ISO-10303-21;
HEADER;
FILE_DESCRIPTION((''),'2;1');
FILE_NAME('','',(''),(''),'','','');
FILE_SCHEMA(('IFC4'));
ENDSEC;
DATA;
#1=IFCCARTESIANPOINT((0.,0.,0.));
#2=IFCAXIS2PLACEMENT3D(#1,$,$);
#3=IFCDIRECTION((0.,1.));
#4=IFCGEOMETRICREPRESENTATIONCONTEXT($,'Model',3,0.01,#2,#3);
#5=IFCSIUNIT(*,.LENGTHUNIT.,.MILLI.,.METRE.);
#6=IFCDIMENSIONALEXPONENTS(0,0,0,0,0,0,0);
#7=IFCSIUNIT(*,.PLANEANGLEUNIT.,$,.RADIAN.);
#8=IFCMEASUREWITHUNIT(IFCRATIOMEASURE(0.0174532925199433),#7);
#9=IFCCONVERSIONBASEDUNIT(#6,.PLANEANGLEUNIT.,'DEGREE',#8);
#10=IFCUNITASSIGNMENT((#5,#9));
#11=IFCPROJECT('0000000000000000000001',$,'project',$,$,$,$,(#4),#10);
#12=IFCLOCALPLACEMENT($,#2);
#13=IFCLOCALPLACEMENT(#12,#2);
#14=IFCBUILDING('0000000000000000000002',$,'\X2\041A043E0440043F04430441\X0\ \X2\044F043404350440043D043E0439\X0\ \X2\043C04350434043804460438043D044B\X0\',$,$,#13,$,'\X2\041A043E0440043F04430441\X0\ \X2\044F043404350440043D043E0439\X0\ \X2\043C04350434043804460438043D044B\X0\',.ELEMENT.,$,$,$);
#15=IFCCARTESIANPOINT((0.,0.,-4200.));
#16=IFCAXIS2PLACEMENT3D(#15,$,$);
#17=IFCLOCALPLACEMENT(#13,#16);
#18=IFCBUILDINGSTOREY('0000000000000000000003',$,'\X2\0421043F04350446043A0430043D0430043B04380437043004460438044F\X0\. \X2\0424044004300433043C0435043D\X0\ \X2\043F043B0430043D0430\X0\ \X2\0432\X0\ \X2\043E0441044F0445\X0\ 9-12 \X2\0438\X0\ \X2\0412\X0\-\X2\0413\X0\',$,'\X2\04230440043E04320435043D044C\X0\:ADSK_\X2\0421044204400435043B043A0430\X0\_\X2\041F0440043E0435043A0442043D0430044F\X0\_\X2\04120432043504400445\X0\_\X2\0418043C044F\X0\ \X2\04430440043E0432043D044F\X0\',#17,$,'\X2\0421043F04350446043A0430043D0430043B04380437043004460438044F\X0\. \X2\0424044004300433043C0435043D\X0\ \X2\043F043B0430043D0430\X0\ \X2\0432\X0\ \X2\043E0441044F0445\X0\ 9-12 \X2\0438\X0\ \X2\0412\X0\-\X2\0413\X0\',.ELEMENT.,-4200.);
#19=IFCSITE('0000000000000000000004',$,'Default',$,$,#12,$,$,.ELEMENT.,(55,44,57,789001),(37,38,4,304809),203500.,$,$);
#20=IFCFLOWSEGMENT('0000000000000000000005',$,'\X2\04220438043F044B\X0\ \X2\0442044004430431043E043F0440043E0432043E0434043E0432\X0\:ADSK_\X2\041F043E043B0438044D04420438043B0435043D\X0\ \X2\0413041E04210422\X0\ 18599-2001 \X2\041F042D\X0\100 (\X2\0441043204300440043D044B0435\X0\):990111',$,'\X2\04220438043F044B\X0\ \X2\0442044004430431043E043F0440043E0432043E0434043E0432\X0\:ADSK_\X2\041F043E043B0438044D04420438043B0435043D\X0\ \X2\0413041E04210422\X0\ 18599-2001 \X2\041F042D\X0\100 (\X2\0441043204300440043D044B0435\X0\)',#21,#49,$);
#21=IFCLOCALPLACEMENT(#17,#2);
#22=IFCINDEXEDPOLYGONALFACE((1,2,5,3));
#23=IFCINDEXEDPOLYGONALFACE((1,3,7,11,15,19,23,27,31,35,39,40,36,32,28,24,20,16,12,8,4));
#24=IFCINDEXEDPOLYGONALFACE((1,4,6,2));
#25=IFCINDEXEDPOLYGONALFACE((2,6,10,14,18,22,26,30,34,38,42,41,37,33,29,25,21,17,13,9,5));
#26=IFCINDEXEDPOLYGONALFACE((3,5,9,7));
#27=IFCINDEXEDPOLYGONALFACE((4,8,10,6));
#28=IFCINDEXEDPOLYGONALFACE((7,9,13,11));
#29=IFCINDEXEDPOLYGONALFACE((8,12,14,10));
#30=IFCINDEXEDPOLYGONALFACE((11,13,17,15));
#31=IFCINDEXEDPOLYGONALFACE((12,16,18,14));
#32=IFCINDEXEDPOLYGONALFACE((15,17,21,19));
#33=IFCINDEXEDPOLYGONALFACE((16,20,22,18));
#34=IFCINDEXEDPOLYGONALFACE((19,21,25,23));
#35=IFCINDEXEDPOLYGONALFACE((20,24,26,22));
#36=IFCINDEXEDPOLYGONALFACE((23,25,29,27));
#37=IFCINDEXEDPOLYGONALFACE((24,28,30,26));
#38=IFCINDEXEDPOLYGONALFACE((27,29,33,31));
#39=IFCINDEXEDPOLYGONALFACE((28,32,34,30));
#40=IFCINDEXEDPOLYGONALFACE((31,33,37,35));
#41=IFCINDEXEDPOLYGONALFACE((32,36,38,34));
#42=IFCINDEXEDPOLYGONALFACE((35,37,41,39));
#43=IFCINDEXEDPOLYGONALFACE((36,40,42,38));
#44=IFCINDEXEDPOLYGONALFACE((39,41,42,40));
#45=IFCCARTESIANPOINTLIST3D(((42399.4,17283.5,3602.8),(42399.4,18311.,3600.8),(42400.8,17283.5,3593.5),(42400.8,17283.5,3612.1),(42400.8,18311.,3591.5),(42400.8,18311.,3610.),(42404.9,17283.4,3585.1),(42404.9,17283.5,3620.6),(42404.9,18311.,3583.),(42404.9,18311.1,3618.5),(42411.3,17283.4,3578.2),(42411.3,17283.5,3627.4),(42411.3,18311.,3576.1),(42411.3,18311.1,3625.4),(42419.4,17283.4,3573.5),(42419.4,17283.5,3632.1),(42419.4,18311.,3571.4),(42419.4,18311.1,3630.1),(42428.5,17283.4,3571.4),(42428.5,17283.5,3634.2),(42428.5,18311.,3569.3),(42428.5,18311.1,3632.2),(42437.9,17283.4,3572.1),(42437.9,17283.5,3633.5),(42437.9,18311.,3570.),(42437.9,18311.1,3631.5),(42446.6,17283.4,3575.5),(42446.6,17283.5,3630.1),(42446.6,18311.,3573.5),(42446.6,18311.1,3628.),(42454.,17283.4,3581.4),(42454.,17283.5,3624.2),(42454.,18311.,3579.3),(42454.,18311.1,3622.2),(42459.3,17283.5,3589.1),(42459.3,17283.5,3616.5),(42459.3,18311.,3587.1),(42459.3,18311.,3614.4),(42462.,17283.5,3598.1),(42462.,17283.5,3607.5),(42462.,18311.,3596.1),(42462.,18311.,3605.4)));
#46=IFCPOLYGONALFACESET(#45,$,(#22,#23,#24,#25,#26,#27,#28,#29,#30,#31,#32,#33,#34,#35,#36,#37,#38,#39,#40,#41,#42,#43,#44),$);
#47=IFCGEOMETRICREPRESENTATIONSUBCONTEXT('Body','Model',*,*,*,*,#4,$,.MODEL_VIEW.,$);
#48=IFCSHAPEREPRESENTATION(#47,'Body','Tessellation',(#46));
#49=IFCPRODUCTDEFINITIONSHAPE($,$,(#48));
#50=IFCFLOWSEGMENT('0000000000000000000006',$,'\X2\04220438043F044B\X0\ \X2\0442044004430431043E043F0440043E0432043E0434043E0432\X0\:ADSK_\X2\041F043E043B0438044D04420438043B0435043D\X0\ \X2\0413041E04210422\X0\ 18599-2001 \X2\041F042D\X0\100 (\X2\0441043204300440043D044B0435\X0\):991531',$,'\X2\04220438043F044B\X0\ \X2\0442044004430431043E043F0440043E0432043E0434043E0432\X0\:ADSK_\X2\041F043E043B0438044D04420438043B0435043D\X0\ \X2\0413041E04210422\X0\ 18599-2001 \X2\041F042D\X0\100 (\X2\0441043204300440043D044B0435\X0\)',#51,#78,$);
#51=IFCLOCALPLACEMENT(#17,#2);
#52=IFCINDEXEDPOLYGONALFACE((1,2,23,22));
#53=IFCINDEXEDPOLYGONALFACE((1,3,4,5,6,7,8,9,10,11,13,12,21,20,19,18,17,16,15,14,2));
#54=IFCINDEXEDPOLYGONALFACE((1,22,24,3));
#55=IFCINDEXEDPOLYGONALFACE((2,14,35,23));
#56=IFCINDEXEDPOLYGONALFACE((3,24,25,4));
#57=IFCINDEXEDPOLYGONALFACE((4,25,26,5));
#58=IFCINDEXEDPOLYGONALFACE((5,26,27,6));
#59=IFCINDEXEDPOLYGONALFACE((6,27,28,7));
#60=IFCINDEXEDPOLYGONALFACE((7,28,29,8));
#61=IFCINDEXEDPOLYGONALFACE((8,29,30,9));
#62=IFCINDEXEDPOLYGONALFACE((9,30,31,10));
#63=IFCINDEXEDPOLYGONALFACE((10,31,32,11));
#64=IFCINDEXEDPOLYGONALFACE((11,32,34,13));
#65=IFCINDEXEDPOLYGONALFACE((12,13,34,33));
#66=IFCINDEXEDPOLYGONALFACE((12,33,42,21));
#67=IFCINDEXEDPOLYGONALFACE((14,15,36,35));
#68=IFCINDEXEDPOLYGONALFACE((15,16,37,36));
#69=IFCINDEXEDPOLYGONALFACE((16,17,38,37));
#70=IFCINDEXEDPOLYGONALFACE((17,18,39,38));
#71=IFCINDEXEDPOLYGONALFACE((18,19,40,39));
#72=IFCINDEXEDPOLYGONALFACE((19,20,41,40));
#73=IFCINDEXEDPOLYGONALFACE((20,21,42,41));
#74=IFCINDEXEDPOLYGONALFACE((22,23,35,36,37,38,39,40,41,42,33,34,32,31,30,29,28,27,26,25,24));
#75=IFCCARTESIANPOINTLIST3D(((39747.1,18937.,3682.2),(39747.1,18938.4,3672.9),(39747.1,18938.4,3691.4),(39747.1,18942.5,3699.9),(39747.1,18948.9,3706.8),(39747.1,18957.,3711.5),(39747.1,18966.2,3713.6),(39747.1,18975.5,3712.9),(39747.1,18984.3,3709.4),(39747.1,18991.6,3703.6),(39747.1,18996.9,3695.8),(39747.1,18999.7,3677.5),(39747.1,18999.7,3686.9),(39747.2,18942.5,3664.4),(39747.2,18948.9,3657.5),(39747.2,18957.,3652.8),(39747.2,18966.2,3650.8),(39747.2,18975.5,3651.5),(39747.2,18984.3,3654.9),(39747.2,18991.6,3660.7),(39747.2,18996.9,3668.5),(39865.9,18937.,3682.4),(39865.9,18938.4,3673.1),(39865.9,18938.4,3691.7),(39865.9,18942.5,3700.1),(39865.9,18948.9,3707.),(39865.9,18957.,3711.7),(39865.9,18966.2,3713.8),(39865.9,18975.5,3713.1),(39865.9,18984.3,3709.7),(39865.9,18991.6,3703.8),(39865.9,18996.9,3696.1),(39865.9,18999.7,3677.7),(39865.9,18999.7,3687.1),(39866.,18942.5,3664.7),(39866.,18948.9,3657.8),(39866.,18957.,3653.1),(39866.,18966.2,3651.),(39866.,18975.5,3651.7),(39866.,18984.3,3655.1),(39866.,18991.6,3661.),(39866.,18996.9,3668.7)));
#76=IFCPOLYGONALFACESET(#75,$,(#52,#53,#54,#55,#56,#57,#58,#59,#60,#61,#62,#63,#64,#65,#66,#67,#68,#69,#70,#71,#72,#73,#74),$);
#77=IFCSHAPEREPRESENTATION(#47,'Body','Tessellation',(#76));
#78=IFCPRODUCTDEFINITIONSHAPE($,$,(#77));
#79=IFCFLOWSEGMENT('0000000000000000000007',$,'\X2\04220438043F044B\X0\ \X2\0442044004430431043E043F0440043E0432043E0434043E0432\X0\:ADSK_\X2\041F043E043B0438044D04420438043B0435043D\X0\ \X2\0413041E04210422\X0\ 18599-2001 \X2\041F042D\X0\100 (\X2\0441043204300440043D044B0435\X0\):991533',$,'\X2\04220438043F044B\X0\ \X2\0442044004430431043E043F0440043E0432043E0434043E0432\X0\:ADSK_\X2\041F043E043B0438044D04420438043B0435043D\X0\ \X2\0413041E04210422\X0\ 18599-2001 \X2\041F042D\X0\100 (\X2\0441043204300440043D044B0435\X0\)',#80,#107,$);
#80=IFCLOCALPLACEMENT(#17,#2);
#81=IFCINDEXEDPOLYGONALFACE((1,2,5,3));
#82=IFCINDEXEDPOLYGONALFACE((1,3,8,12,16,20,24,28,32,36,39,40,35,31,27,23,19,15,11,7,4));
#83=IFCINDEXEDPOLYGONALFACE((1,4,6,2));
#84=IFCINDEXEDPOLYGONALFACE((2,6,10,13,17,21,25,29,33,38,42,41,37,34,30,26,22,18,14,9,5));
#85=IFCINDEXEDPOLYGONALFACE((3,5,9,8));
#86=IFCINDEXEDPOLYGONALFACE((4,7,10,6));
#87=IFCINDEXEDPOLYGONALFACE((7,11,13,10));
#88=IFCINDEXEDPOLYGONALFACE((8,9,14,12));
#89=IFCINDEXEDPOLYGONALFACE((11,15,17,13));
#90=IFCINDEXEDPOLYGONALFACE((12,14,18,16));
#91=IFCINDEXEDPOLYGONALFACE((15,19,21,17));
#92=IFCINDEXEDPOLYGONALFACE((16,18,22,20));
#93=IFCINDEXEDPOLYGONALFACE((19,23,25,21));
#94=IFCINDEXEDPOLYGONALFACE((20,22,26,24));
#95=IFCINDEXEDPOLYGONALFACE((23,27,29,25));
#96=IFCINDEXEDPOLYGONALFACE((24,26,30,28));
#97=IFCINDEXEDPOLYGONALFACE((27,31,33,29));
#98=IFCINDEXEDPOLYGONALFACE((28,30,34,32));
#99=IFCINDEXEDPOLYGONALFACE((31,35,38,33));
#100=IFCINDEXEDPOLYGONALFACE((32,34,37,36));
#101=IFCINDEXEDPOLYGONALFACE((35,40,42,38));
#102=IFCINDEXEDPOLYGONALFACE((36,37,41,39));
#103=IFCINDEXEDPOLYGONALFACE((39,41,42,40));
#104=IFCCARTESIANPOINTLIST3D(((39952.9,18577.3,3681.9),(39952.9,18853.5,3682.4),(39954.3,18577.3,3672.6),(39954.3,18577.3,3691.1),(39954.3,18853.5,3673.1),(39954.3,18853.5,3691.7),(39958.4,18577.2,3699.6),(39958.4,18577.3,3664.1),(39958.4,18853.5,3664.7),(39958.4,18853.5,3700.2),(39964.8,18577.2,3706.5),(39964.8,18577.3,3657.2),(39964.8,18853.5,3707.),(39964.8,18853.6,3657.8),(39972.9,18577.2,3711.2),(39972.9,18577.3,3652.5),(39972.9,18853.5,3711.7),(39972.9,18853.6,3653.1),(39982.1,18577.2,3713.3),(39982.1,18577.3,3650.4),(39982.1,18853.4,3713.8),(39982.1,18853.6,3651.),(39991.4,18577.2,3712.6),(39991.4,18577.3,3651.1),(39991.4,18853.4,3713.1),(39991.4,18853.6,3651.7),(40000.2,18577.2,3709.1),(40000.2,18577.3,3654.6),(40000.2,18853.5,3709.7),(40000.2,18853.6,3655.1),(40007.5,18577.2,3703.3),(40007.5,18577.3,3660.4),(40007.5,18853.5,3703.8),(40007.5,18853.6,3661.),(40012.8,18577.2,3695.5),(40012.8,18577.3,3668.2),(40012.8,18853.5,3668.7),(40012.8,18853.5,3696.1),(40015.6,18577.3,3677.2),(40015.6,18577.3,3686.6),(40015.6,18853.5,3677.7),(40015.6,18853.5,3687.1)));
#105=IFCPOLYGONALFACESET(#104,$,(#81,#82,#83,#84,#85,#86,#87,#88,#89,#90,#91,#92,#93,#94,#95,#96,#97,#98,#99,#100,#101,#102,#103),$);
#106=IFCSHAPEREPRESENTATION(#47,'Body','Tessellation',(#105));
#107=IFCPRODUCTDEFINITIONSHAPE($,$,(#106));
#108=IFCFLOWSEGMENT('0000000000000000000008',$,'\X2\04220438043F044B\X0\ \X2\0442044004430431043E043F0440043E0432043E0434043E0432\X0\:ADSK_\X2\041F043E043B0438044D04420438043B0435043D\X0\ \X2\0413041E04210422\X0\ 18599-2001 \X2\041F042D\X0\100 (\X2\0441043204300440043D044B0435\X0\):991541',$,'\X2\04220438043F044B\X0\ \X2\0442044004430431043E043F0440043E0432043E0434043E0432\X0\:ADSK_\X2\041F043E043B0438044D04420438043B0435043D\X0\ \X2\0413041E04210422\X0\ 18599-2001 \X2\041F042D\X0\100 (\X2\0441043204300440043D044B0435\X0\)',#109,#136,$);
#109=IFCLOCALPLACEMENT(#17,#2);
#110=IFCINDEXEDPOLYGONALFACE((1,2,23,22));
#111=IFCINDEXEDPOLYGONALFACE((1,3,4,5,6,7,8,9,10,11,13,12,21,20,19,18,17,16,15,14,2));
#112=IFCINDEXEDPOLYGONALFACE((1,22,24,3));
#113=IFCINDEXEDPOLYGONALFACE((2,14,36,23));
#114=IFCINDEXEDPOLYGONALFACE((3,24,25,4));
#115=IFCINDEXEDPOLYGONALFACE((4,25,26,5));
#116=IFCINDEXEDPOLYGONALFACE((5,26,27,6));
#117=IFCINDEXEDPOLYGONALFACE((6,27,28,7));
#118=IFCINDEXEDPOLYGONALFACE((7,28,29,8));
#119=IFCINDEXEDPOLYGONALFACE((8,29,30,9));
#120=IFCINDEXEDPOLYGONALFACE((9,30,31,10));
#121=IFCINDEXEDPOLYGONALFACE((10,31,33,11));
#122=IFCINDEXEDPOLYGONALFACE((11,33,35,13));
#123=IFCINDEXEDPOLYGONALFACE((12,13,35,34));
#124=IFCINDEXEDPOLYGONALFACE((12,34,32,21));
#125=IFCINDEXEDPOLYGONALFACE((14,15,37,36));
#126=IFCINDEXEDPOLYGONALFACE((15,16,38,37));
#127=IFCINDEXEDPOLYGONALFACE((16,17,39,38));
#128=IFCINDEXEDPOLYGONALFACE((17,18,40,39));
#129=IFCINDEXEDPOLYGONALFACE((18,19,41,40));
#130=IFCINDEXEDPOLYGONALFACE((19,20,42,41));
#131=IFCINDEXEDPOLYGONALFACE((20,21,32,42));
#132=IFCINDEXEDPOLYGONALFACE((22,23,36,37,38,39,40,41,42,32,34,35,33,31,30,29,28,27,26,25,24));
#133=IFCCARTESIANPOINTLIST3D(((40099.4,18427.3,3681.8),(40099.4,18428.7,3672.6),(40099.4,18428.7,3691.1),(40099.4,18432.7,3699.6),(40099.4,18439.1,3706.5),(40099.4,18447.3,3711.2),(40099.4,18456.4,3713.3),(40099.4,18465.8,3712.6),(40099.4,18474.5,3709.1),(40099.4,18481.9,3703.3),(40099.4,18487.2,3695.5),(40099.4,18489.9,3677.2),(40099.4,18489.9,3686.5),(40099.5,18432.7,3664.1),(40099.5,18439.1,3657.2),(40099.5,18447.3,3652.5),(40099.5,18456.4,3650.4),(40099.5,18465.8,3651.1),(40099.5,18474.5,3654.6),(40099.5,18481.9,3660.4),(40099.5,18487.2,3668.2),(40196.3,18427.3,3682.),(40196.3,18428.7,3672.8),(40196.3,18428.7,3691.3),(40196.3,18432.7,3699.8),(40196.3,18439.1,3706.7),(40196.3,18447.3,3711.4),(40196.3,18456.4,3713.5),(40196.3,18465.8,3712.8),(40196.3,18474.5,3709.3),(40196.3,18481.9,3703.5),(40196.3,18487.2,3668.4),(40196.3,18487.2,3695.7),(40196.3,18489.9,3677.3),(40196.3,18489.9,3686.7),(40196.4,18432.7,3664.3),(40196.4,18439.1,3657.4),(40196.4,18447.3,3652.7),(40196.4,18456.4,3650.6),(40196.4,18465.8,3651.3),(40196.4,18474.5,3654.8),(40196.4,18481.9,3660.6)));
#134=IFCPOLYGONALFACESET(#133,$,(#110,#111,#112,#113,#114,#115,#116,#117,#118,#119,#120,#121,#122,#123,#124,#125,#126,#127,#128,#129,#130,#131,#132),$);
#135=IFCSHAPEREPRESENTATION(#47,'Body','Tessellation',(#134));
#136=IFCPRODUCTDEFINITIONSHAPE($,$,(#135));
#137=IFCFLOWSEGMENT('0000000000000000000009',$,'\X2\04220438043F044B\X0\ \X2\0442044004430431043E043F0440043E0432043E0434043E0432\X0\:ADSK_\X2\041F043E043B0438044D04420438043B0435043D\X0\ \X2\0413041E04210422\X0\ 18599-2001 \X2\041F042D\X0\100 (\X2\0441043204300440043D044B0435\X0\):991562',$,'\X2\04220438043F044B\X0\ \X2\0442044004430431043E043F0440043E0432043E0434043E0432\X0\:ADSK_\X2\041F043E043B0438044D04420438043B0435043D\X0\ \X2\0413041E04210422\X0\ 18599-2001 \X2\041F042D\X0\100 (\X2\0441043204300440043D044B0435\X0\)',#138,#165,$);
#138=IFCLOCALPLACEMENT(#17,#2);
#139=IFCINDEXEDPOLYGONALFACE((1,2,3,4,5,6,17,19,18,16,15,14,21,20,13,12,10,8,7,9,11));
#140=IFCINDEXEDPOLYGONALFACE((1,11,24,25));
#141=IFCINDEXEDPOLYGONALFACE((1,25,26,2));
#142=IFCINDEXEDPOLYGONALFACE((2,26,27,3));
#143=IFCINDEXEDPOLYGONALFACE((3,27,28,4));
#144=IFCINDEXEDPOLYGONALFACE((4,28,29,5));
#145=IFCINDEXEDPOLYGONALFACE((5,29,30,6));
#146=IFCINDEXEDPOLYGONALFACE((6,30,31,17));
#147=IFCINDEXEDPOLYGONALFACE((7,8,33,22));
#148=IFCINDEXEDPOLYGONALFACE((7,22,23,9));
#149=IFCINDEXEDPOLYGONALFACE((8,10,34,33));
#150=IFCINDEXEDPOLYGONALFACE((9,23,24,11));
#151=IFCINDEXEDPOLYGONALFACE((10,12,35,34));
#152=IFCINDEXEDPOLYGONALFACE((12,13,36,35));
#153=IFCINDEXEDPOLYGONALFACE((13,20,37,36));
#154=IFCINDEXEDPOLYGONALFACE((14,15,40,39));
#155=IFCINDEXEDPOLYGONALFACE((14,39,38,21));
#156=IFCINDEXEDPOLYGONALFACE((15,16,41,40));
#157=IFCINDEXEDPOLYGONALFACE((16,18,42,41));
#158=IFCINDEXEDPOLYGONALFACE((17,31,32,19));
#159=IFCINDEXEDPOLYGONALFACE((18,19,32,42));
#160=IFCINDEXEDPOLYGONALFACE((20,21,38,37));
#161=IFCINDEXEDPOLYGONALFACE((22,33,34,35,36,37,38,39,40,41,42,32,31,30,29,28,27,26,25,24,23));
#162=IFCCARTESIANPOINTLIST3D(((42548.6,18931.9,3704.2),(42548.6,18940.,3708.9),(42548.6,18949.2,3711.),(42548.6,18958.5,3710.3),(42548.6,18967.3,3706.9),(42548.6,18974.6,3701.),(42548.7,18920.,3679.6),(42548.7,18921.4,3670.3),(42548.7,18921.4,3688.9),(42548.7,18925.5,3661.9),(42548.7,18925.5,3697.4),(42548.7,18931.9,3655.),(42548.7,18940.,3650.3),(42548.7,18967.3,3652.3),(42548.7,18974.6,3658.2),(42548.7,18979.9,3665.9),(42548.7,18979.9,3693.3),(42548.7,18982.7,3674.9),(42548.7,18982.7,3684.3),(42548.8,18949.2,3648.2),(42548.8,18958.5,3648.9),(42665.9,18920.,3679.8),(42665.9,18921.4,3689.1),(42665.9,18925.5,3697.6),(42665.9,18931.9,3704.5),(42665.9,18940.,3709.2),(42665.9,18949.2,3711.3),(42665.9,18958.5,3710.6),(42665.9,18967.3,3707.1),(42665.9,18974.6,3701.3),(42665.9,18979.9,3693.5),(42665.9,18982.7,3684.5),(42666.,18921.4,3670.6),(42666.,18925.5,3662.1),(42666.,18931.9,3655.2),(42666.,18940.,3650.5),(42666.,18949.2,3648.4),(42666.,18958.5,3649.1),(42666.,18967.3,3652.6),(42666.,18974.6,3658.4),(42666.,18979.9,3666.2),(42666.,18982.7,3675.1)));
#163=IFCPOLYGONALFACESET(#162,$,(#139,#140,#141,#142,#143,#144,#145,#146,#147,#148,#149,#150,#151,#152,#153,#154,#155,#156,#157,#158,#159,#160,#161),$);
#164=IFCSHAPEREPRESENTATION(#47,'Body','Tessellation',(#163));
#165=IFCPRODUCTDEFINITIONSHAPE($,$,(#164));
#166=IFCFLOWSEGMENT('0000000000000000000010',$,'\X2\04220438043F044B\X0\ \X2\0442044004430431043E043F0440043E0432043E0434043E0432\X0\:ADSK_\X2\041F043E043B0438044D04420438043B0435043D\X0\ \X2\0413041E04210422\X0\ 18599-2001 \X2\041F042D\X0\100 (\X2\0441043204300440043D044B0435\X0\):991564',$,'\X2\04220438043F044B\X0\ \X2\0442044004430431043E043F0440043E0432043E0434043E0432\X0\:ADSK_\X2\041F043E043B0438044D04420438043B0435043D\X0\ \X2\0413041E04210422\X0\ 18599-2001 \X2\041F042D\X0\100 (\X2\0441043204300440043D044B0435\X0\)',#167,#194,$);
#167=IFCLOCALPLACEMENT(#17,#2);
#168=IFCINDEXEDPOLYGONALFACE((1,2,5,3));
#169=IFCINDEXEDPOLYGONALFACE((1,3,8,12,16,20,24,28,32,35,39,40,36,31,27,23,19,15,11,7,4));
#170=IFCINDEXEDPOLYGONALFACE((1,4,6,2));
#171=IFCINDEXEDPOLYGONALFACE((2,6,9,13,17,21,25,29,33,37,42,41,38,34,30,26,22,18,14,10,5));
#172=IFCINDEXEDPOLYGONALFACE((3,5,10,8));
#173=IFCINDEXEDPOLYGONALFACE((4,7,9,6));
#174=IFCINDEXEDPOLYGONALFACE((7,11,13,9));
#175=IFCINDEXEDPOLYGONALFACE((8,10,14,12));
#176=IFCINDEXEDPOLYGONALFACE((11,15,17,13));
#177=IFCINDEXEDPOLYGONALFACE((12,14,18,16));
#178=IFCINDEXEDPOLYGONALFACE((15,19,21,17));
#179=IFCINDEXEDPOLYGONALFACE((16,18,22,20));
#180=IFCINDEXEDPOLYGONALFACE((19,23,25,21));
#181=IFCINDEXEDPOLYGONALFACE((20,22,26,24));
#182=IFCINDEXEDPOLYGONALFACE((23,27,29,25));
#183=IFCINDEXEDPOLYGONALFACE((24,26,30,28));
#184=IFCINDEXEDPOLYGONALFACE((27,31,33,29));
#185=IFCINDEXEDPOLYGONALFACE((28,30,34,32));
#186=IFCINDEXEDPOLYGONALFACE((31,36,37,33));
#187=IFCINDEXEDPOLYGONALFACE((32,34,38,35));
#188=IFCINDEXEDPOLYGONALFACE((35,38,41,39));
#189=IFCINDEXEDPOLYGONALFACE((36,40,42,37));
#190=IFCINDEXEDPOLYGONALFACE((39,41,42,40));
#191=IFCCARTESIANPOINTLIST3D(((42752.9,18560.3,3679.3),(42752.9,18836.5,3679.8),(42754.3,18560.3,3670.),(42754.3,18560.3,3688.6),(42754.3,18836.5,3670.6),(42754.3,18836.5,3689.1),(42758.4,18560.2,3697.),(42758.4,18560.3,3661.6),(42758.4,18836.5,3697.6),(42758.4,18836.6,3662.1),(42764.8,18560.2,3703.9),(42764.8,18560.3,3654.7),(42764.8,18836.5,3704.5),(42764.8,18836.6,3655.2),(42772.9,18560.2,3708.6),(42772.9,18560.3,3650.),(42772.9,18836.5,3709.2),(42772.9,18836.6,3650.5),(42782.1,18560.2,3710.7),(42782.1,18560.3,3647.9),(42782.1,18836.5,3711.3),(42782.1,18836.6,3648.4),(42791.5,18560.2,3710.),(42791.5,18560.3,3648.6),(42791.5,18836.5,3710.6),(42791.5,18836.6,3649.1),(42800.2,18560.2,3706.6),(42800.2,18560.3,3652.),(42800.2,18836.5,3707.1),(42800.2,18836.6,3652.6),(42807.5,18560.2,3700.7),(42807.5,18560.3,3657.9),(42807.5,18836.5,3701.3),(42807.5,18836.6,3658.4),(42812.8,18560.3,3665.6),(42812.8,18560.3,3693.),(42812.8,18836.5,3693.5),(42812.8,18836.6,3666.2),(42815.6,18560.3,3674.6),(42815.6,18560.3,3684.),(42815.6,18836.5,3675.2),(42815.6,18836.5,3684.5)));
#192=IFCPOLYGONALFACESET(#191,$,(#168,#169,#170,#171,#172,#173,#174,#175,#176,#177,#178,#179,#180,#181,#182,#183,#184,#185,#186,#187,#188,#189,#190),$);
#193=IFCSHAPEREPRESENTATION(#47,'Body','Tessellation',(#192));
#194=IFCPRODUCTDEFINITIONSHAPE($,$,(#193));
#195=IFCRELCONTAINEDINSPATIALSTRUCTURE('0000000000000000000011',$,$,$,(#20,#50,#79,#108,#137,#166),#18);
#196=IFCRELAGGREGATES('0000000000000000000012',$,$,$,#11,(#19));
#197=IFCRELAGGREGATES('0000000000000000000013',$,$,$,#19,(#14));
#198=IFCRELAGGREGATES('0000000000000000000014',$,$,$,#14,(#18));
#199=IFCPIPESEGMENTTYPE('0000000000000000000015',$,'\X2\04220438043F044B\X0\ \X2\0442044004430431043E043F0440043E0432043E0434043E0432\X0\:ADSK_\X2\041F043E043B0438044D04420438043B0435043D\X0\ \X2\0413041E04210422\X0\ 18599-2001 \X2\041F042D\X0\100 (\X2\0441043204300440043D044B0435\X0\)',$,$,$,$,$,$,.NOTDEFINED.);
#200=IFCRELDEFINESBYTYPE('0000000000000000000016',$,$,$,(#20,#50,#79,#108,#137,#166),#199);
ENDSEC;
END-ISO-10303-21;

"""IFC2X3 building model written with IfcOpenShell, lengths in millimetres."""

from ifc_helpers import new_model, entity, si_unit, converted_unit, direction, frame, frame_2d, origin, origin_2d_with_axis, place, context, subcontext, project, spatial, circle, extrude, type_object, element, save


model = new_model("IFC2X3")

# Units and contexts
model_context = context("Model", 3, precision=0.01, world=origin(), true_north=direction((0.0, 1.0)))
body_context = subcontext(model_context, "Body", "Model", "MODEL_VIEW")
ifc_project = project(units=[si_unit("LENGTHUNIT", "METRE", prefix="MILLI"), converted_unit("PLANEANGLEUNIT", "DEGREE", entity("IfcRatioMeasure", 0.0174532925199433), si_unit("PLANEANGLEUNIT", "RADIAN"), dimensions=[0, 0, 0, 0, 0, 0, 0])], contexts=[model_context])

# Site, building, storey
site_placement = place(None, frame((0.0, 0.0, 0.0)))
site = spatial("IfcSite", under=ifc_project, at=site_placement, Name="Default", CompositionType="ELEMENT", RefLatitude=(55, 44, 57, 789001), RefLongitude=(37, 38, 4, 304809), RefElevation=203500.0)
building_placement = place(site_placement, origin())
building = spatial("IfcBuilding", under=site, at=building_placement, Name="Корпус ядерной медицины", LongName="Корпус ядерной медицины", CompositionType="ELEMENT")
storey_placement = place(building_placement, frame((0.0, 0.0, -4200.0)))
storey = spatial("IfcBuildingStorey", under=building, at=storey_placement, Name="Спецканализация. Фрагмен плана в осях 9-12 и В-Г", ObjectType="Уровень:ADSK_Стрелка_Проектная_Вверх_Имя уровня", LongName="Спецканализация. Фрагмен плана в осях 9-12 и В-Г", CompositionType="ELEMENT", Elevation=-4200.0)

# Flow segments
pipe_segment_type = type_object("IfcPipeSegmentType", Name="Типы трубопроводов:ADSK_Полиэтилен ГОСТ 18599-2001 ПЭ100 (сварные)", PredefinedType="NOTDEFINED")
flow_segment_1_placement = place(storey_placement, frame((42397.8, 17283.4, 3567.7)))
element("IfcFlowSegment", 1, at=flow_segment_1_placement, inside=storey, type_object=pipe_segment_type, Name="Типы трубопроводов:ADSK_Полиэтилен ГОСТ 18599-2001 ПЭ100 (сварные):990111", ObjectType="Типы трубопроводов:ADSK_Полиэтилен ГОСТ 18599-2001 ПЭ100 (сварные)", context=body_context, shape_type="SweptSolid", body=[
    extrude(circle(Radius=31.5, at=frame_2d((0.0, 0.0), x_axis=(1.0, 0.0))), frame((33.1, 1027.6, 33.1), z_axis=(0.0, -0.999998, 0.002), x_axis=(-1.0, 0.0, 0.0)), (0.0, 0.0, 1.0), 1027.5),
])
flow_segment_2_placement = place(storey_placement, frame((39747.1, 18935.4, 3649.1)))
element("IfcFlowSegment", 2, at=flow_segment_2_placement, inside=storey, type_object=pipe_segment_type, Name="Типы трубопроводов:ADSK_Полиэтилен ГОСТ 18599-2001 ПЭ100 (сварные):991531", ObjectType="Типы трубопроводов:ADSK_Полиэтилен ГОСТ 18599-2001 ПЭ100 (сварные)", context=body_context, shape_type="SweptSolid", body=[
    extrude(circle(Radius=31.5, at=origin_2d_with_axis()), frame((0.1, 33.1, 33.1), z_axis=(0.999998, -0.000005, 0.002), x_axis=(-0.000005, -1.0, 0.0)), (0.0, 0.0, 1.0), 118.8),
])
flow_segment_3_placement = place(storey_placement, frame((39951.3, 18577.2, 3648.8)))
element("IfcFlowSegment", 3, at=flow_segment_3_placement, inside=storey, type_object=pipe_segment_type, Name="Типы трубопроводов:ADSK_Полиэтилен ГОСТ 18599-2001 ПЭ100 (сварные):991533", ObjectType="Типы трубопроводов:ADSK_Полиэтилен ГОСТ 18599-2001 ПЭ100 (сварные)", context=body_context, shape_type="SweptSolid", body=[
    extrude(circle(Radius=31.5, at=frame_2d((0.0, 0.0), x_axis=(1.0, 0.0))), frame((33.1, 0.1, 33.1), z_axis=(-0.000004, 0.999998, 0.002), x_axis=(-1.0, -0.000004, 0.0)), (0.0, 0.0, 1.0), 276.2),
])
flow_segment_4_placement = place(storey_placement, frame((40099.4, 18425.7, 3648.8)))
element("IfcFlowSegment", 4, at=flow_segment_4_placement, inside=storey, type_object=pipe_segment_type, Name="Типы трубопроводов:ADSK_Полиэтилен ГОСТ 18599-2001 ПЭ100 (сварные):991541", ObjectType="Типы трубопроводов:ADSK_Полиэтилен ГОСТ 18599-2001 ПЭ100 (сварные)", context=body_context, shape_type="SweptSolid", body=[
    extrude(circle(Radius=31.5, at=origin_2d_with_axis()), frame((0.1, 33.1, 33.1), z_axis=(0.999998, 0.0, 0.001997), x_axis=(0.0, -1.0, 0.0)), (0.0, 0.0, 1.0), 96.9),
])
flow_segment_5_placement = place(storey_placement, frame((42548.6, 18918.4, 3646.5)))
element("IfcFlowSegment", 5, at=flow_segment_5_placement, inside=storey, type_object=pipe_segment_type, Name="Типы трубопроводов:ADSK_Полиэтилен ГОСТ 18599-2001 ПЭ100 (сварные):991562", ObjectType="Типы трубопроводов:ADSK_Полиэтилен ГОСТ 18599-2001 ПЭ100 (сварные)", context=body_context, shape_type="SweptSolid", body=[
    extrude(circle(Radius=31.5, at=origin_2d_with_axis()), frame((0.1, 33.1, 33.1), z_axis=(0.999998, -0.000005, 0.002), x_axis=(-0.000005, -1.0, 0.0)), (0.0, 0.0, 1.0), 117.3),
])
flow_segment_6_placement = place(storey_placement, frame((42751.3, 18560.2, 3646.2)))
element("IfcFlowSegment", 6, at=flow_segment_6_placement, inside=storey, type_object=pipe_segment_type, Name="Типы трубопроводов:ADSK_Полиэтилен ГОСТ 18599-2001 ПЭ100 (сварные):991564", ObjectType="Типы трубопроводов:ADSK_Полиэтилен ГОСТ 18599-2001 ПЭ100 (сварные)", context=body_context, shape_type="SweptSolid", body=[
    extrude(circle(Radius=31.5, at=frame_2d((0.0, 0.0), x_axis=(1.0, 0.0))), frame((33.1, 0.1, 33.1), z_axis=(-0.000004, 0.999998, 0.002), x_axis=(-1.0, -0.000004, 0.0)), (0.0, 0.0, 1.0), 276.3),
])

save(model, "model.ifc")
